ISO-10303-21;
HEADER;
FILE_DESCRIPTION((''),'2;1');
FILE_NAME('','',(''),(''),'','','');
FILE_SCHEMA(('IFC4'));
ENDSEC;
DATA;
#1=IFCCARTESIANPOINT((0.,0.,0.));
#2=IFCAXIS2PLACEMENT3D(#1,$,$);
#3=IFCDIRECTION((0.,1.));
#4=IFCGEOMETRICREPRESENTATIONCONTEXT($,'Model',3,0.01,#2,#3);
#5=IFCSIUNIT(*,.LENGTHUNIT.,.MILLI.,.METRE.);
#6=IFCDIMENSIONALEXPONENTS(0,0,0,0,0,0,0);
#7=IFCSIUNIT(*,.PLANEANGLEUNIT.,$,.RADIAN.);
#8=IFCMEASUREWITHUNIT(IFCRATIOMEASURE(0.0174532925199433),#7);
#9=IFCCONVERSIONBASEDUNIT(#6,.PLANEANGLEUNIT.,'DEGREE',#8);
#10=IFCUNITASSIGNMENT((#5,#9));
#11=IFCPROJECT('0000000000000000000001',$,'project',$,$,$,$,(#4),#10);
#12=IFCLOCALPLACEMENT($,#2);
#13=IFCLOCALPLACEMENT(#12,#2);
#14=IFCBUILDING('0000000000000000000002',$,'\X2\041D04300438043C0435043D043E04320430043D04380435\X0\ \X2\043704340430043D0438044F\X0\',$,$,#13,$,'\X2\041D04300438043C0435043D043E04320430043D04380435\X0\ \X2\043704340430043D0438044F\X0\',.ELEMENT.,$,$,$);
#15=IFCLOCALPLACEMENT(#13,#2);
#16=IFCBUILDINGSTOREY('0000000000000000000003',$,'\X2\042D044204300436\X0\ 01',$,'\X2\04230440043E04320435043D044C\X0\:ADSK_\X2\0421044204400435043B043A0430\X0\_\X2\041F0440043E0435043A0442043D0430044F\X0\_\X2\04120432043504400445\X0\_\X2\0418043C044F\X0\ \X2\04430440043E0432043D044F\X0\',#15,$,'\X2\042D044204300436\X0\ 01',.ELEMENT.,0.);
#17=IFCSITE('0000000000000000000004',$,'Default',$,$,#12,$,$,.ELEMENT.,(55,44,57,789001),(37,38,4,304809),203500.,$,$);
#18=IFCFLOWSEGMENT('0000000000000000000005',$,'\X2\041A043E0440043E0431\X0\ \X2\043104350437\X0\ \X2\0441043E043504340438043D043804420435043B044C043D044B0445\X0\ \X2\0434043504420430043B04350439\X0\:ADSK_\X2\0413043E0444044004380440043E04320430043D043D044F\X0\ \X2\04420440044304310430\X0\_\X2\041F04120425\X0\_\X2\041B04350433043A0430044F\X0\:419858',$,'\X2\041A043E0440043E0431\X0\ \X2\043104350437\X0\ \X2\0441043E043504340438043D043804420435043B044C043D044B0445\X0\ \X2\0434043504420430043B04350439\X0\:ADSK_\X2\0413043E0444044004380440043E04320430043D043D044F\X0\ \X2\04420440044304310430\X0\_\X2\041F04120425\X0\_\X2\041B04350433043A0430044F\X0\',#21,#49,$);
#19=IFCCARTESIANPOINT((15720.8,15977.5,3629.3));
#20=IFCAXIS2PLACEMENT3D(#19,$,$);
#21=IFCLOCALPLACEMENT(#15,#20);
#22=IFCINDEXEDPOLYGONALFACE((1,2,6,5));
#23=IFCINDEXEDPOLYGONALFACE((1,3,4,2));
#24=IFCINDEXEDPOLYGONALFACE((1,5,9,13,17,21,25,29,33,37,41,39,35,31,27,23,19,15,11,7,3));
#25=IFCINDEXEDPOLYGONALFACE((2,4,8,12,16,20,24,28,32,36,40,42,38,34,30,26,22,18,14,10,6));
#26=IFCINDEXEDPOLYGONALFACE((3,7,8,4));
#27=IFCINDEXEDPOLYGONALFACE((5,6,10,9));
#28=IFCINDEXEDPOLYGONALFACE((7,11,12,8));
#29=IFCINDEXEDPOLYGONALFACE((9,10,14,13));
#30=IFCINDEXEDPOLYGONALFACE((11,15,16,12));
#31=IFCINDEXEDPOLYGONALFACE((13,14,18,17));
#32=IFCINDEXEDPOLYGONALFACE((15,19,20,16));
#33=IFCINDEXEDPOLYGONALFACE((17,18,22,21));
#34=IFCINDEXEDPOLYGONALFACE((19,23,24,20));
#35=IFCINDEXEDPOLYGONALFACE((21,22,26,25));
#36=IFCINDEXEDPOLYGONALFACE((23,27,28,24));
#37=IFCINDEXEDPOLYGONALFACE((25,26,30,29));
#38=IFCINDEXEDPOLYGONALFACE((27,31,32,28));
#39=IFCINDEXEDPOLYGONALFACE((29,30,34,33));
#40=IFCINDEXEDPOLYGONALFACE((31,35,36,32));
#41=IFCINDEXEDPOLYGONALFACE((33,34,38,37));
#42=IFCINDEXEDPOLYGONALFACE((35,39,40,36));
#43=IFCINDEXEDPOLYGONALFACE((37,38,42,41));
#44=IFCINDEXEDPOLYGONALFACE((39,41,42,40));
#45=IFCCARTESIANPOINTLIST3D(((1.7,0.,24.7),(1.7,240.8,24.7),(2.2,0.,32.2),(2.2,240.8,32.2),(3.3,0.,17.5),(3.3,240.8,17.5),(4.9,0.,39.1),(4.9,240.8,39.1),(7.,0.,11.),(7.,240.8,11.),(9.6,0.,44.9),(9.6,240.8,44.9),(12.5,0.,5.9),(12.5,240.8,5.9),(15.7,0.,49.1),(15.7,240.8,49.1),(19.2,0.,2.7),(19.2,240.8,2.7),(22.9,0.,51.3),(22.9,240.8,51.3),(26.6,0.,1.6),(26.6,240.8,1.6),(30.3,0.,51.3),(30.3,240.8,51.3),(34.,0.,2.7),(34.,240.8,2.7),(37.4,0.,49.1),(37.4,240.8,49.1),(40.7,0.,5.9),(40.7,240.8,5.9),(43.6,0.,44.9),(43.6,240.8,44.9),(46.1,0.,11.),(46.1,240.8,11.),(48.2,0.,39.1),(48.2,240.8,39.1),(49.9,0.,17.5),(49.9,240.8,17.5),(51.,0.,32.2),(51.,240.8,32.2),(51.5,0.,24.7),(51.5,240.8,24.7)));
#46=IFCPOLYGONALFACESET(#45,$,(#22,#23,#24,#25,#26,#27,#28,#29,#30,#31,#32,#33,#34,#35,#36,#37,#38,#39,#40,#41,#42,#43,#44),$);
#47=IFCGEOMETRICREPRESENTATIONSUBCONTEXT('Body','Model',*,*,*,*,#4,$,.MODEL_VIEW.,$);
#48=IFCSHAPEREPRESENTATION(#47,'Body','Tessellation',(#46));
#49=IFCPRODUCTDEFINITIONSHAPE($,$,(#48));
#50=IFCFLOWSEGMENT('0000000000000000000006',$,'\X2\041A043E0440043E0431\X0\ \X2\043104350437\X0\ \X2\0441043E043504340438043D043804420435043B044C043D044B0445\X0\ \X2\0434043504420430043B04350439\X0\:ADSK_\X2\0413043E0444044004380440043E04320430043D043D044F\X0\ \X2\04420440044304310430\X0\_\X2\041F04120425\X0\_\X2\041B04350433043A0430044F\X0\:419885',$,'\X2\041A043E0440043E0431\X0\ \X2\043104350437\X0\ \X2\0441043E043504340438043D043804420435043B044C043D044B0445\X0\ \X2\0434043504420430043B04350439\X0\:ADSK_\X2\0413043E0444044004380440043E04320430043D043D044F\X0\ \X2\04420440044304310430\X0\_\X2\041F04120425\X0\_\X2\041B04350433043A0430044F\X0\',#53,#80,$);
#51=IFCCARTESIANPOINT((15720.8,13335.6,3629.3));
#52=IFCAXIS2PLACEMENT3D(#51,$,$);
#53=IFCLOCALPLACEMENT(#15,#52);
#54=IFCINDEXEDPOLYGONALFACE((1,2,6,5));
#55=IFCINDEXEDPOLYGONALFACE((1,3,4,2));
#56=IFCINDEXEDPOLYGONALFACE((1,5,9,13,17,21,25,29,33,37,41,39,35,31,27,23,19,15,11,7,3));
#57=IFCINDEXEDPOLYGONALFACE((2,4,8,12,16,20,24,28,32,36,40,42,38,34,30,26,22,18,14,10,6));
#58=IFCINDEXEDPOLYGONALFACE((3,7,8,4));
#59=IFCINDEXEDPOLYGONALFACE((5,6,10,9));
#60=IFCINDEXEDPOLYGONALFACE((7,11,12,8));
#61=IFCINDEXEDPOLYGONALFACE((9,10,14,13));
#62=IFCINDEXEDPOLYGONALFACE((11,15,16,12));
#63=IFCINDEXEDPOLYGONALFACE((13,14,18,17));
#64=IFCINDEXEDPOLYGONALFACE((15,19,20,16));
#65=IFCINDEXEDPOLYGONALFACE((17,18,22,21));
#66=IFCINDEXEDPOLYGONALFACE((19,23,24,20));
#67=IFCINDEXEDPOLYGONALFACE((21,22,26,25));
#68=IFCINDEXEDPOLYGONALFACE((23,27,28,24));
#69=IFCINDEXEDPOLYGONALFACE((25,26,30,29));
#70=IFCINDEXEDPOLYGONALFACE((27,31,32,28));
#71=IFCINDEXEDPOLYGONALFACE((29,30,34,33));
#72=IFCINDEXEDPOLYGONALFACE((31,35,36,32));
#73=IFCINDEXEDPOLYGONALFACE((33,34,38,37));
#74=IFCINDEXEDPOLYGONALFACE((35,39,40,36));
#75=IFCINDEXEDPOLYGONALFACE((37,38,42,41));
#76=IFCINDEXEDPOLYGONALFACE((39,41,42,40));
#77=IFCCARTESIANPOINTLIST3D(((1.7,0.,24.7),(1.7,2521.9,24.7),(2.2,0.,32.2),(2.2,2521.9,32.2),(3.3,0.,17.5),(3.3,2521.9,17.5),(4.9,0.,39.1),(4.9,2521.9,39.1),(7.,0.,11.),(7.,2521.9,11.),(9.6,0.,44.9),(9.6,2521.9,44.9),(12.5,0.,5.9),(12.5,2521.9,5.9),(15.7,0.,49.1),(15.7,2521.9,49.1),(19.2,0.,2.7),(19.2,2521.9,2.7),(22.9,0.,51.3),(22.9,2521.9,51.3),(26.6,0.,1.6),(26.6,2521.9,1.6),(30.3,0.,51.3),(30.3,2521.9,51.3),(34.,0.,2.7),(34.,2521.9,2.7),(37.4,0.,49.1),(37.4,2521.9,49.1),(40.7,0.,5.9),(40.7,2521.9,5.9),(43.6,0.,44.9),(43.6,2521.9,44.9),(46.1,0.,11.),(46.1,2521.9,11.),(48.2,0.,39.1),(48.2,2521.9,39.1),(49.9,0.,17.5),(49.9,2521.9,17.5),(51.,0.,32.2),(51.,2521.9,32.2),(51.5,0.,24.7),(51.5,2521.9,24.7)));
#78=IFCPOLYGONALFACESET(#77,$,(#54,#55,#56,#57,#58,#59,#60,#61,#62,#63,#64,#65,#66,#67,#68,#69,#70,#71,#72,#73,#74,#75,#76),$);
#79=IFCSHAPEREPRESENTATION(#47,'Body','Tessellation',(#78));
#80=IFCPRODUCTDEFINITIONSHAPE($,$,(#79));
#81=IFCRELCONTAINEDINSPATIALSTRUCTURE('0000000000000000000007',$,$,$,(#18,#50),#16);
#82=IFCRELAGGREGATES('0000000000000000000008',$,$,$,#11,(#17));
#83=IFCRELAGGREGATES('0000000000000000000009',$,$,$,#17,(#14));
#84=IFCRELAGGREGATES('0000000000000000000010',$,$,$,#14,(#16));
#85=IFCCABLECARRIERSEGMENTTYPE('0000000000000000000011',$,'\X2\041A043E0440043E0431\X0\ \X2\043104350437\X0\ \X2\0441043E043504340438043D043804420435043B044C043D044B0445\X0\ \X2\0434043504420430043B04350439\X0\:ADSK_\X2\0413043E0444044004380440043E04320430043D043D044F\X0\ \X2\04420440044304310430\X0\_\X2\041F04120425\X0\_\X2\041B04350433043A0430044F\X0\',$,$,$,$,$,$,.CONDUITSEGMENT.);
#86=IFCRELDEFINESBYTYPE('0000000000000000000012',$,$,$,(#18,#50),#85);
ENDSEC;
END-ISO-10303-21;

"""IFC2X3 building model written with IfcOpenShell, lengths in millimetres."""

from ifc_helpers import new_model, entity, si_unit, converted_unit, direction, frame, frame_2d, origin, place, context, subcontext, project, spatial, circle, extrude, type_object, element, save


model = new_model("IFC2X3")

# Units and contexts
model_context = context("Model", 3, precision=0.01, world=origin(), true_north=direction((0.0, 1.0)))
body_context = subcontext(model_context, "Body", "Model", "MODEL_VIEW")
ifc_project = project(units=[si_unit("LENGTHUNIT", "METRE", prefix="MILLI"), converted_unit("PLANEANGLEUNIT", "DEGREE", entity("IfcRatioMeasure", 0.0174532925199433), si_unit("PLANEANGLEUNIT", "RADIAN"), dimensions=[0, 0, 0, 0, 0, 0, 0])], contexts=[model_context])

# Site, building, storey
site_placement = place(None, frame((0.0, 0.0, 0.0)))
site = spatial("IfcSite", under=ifc_project, at=site_placement, Name="Default", CompositionType="ELEMENT", RefLatitude=(55, 44, 57, 789001), RefLongitude=(37, 38, 4, 304809), RefElevation=203500.0)
building_placement = place(site_placement, origin())
building = spatial("IfcBuilding", under=site, at=building_placement, Name="Наименование здания", LongName="Наименование здания", CompositionType="ELEMENT")
storey_placement = place(building_placement, origin())
storey = spatial("IfcBuildingStorey", under=building, at=storey_placement, Name="Этаж 01", ObjectType="Уровень:ADSK_Стрелка_Проектная_Вверх_Имя уровня", LongName="Этаж 01", CompositionType="ELEMENT", Elevation=0.0)

# Flow segments
cable_carrier_segment_type = type_object("IfcCableCarrierSegmentType", Name="Короб без соединительных деталей:ADSK_Гофрировання труба_ПВХ_Легкая", PredefinedType="CONDUITSEGMENT")
flow_segment_1_placement = place(storey_placement, frame((15720.8, 15977.5, 3629.3)))
element("IfcFlowSegment", 1, at=flow_segment_1_placement, inside=storey, type_object=cable_carrier_segment_type, Name="Короб без соединительных деталей:ADSK_Гофрировання труба_ПВХ_Легкая:419858", ObjectType="Короб без соединительных деталей:ADSK_Гофрировання труба_ПВХ_Легкая", context=body_context, shape_type="SweptSolid", body=[
    extrude(circle(Radius=25.0, at=frame_2d((0.0, 0.0), x_axis=(1.0, 0.0))), frame((26.6, 0.0, 26.6), z_axis=(0.0, 1.0, 0.0), x_axis=(0.0, 0.0, -1.0)), (0.0, 0.0, 1.0), 240.8),
])
flow_segment_2_placement = place(storey_placement, frame((15720.8, 13335.6, 3629.3)))
element("IfcFlowSegment", 2, at=flow_segment_2_placement, inside=storey, type_object=cable_carrier_segment_type, Name="Короб без соединительных деталей:ADSK_Гофрировання труба_ПВХ_Легкая:419885", ObjectType="Короб без соединительных деталей:ADSK_Гофрировання труба_ПВХ_Легкая", context=body_context, shape_type="SweptSolid", body=[
    extrude(circle(Radius=25.0, at=frame_2d((0.0, 0.0), x_axis=(1.0, 0.0))), frame((26.6, 0.0, 26.6), z_axis=(0.0, 1.0, 0.0), x_axis=(0.0, 0.0, -1.0)), (0.0, 0.0, 1.0), 2521.9),
])

save(model, "model.ifc")
